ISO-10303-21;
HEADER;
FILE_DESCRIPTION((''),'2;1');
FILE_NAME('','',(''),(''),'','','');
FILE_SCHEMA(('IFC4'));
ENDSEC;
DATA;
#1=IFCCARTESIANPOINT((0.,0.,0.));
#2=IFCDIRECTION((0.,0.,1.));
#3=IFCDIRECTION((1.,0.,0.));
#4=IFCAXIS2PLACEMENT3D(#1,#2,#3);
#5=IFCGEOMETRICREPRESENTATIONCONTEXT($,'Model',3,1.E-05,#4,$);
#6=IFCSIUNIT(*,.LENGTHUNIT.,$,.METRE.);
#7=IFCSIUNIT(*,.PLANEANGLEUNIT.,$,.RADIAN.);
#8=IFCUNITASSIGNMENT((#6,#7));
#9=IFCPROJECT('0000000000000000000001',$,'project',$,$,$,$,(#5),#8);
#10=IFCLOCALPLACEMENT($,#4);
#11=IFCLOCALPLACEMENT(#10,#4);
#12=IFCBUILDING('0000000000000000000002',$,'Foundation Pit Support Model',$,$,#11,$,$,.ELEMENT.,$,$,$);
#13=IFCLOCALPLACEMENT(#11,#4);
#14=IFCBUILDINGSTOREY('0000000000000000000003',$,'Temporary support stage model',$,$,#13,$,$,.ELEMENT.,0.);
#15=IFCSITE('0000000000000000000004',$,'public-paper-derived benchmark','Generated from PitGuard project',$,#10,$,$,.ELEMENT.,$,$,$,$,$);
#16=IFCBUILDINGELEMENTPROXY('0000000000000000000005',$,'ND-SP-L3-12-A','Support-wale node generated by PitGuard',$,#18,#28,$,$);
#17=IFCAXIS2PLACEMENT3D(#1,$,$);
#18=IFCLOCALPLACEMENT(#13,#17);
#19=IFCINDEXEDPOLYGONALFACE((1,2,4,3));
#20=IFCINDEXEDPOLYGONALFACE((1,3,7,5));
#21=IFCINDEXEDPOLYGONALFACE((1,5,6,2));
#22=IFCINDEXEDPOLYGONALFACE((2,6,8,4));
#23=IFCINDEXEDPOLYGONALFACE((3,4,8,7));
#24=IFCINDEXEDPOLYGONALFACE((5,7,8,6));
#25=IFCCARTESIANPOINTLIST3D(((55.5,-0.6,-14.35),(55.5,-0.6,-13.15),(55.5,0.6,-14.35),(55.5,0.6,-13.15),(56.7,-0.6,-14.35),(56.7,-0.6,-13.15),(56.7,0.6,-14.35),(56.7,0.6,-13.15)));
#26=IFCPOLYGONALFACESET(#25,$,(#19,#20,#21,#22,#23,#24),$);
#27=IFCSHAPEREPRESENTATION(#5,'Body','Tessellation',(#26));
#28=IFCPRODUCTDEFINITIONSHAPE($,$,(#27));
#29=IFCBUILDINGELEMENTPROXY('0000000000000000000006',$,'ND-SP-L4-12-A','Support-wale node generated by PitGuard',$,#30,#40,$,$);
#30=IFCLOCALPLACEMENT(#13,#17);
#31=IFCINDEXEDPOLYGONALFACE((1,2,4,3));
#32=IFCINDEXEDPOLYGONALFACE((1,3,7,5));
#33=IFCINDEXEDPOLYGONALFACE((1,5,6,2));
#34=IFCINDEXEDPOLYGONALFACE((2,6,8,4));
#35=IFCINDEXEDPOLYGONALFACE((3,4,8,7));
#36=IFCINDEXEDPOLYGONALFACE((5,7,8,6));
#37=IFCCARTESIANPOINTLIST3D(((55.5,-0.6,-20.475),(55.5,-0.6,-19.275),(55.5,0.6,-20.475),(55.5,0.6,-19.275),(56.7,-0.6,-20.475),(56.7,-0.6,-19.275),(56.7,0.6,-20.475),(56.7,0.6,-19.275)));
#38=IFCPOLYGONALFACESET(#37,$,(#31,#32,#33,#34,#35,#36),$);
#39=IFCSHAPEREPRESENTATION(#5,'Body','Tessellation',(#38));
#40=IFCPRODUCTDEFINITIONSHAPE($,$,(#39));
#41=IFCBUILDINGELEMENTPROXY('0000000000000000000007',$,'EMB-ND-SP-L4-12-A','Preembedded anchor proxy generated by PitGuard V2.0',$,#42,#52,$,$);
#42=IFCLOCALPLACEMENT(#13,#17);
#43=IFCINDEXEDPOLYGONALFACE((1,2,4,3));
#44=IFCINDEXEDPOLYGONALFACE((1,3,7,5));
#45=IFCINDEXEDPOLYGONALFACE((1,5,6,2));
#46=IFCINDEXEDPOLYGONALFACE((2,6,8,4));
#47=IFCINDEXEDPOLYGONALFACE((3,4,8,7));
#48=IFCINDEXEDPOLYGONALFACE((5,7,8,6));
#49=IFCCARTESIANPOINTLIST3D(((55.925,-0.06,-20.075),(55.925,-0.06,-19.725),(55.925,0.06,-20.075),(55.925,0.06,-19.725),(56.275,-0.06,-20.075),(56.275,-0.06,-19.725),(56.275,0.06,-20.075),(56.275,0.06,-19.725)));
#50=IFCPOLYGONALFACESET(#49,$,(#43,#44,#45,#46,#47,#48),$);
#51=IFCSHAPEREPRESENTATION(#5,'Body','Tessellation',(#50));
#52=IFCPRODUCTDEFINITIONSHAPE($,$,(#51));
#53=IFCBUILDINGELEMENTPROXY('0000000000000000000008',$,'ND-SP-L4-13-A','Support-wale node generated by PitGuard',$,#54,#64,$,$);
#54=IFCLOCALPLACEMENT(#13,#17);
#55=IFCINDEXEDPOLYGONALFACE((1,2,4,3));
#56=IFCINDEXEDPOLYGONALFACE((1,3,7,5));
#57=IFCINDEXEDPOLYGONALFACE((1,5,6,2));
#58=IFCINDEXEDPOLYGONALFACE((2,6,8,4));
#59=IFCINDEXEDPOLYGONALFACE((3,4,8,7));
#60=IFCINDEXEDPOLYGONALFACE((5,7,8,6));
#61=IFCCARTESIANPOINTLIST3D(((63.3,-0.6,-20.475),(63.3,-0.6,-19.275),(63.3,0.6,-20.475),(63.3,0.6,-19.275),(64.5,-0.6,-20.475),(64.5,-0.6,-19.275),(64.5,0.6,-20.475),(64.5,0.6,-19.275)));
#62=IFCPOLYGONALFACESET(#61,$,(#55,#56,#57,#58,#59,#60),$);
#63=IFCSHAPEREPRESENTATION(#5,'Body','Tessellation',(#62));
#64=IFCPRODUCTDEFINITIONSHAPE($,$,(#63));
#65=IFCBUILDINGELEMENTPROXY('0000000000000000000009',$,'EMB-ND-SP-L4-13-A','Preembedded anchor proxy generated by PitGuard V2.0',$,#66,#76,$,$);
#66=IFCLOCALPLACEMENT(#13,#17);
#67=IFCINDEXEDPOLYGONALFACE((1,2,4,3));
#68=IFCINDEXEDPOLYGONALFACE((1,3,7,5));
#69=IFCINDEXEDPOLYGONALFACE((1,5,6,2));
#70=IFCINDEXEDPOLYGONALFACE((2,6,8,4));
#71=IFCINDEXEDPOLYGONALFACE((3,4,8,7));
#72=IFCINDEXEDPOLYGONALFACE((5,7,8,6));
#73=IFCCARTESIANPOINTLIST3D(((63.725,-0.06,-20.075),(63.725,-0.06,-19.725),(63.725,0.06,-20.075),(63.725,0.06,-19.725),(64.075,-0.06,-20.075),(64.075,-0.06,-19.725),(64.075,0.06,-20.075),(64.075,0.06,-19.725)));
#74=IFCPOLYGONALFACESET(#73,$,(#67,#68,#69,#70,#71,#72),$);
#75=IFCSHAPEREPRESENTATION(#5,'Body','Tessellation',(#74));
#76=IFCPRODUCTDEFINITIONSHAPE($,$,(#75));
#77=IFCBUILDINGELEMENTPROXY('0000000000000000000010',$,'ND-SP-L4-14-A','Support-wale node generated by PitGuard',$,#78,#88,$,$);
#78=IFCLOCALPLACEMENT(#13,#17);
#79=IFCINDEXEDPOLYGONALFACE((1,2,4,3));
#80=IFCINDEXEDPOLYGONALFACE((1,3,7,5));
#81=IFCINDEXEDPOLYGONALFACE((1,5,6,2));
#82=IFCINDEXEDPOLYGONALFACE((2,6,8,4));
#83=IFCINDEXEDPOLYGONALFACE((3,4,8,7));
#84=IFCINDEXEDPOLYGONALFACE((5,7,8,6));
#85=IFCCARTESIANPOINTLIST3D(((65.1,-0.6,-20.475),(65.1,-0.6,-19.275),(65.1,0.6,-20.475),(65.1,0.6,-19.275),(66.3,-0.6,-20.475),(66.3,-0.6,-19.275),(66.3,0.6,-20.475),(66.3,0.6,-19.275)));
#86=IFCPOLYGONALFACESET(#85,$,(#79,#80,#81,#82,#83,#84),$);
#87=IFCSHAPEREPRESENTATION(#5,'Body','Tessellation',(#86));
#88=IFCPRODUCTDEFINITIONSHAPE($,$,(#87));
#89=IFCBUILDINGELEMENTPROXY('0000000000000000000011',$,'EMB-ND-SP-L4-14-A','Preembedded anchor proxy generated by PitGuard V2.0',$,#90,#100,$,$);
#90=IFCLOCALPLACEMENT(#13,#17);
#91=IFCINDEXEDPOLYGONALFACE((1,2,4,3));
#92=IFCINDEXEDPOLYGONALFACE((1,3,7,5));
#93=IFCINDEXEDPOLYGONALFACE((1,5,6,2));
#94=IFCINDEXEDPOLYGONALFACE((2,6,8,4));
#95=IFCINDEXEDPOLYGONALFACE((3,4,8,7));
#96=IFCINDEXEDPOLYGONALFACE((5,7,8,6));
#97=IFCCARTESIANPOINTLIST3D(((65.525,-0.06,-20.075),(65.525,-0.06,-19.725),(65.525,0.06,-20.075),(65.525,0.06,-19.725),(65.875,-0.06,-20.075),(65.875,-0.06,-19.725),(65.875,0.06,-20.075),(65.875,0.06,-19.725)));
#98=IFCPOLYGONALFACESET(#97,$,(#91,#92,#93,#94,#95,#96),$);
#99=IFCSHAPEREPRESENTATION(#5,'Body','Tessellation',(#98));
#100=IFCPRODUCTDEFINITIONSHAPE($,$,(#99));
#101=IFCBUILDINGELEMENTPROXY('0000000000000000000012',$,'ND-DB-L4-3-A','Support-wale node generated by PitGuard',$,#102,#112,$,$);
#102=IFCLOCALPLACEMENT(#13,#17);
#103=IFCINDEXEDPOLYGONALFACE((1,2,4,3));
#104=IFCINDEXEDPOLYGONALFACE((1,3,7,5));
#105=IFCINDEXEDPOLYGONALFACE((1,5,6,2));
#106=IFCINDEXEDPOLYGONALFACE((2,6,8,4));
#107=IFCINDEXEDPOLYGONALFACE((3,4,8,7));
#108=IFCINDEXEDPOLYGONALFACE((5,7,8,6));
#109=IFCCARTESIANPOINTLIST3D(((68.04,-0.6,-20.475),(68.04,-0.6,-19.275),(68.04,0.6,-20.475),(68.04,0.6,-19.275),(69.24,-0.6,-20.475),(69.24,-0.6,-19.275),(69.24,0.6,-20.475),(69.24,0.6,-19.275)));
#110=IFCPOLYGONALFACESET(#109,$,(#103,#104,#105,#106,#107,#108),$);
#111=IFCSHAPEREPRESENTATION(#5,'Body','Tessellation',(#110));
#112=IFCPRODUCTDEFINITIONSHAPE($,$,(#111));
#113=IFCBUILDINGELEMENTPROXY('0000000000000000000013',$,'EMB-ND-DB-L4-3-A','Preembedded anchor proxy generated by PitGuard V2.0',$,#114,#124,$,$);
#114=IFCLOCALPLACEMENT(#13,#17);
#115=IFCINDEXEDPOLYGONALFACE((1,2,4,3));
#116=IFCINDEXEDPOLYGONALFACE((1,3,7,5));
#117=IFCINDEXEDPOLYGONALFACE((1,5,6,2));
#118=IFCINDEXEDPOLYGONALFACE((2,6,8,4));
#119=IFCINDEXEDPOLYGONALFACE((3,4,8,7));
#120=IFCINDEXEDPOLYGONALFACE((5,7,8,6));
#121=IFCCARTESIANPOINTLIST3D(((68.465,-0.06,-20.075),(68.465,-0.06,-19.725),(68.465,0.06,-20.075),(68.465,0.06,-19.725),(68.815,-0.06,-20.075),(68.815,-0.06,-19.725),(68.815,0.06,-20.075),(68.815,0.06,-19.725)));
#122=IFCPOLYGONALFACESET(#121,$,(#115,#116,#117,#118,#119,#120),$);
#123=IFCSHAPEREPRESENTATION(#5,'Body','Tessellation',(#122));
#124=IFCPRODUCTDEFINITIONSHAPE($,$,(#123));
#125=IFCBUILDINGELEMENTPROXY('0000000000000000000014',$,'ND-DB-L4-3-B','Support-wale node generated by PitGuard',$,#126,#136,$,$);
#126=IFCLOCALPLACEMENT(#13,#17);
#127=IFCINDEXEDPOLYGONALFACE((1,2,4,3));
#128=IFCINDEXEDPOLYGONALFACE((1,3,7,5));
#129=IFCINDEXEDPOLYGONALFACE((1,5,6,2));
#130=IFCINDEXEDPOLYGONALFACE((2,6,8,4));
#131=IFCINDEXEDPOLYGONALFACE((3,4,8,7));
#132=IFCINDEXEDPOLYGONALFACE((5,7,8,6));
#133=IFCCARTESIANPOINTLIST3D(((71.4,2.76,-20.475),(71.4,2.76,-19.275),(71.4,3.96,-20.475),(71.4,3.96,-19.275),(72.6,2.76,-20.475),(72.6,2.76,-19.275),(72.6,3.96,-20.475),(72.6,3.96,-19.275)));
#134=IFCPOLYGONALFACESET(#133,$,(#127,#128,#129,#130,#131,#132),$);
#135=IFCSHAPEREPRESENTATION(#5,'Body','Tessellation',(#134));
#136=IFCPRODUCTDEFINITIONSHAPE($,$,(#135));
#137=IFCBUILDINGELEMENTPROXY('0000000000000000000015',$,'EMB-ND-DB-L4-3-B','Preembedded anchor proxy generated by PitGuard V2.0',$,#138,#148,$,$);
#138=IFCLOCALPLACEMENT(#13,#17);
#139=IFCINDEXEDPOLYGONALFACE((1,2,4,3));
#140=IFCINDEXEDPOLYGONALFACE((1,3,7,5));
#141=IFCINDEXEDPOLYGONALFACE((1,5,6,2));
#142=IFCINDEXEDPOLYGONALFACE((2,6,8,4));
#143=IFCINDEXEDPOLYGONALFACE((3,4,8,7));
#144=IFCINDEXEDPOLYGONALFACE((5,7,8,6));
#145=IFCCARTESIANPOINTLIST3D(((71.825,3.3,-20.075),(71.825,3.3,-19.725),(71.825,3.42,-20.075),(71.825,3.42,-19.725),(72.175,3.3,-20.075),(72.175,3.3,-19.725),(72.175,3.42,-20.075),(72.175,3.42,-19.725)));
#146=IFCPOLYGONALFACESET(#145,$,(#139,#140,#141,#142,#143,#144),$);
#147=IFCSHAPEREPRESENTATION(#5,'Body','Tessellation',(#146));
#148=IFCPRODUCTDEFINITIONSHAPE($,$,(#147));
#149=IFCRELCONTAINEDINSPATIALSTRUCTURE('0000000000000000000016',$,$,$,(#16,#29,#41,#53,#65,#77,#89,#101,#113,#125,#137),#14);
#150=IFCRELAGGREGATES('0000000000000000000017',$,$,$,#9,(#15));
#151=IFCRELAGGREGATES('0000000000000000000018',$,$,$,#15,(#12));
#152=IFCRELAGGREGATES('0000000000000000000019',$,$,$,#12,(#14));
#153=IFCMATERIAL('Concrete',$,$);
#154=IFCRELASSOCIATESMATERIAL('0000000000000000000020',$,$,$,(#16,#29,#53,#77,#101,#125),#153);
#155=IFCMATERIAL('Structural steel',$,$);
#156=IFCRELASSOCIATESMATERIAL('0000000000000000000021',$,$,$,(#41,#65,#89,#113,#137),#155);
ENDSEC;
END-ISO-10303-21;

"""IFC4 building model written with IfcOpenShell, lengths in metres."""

from ifc_helpers import new_model, si_unit, frame, origin_with_axes, origin_2d, place, context, project, spatial, rectangle, extrude, material, element, save


model = new_model("IFC4")

# Units and contexts
model_context = context("Model", 3, precision=1e-05, world=origin_with_axes())
ifc_project = project(units=[si_unit("LENGTHUNIT", "METRE"), si_unit("PLANEANGLEUNIT", "RADIAN")], contexts=[model_context])

# Site, building, storey
site_placement = place(None, origin_with_axes())
site = spatial("IfcSite", under=ifc_project, at=site_placement, Name="public-paper-derived benchmark", Description="Generated from PitGuard project", CompositionType="ELEMENT")
building_placement = place(site_placement, origin_with_axes())
building = spatial("IfcBuilding", under=site, at=building_placement, Name="Foundation Pit Support Model", CompositionType="ELEMENT")
storey_placement = place(building_placement, origin_with_axes())
storey = spatial("IfcBuildingStorey", under=building, at=storey_placement, Name="Temporary support stage model", CompositionType="ELEMENT", Elevation=0.0)

# Shared definitions
ifc_material_1 = material(Name="Concrete")

# Shared definitions
ifc_material_2 = material(Name="Structural steel")

# Building element proxies
for number, where, z_axis, x_axis, name in (
    (1, (56.1, 0.0, -14.35), (0.0, 0.0, 1.0), (1.0, 0.0, 0.0), "ND-SP-L3-12-A"),
    (2, (56.1, 0.0, -20.475), (0.0, 0.0, 1.0), (1.0, 0.0, 0.0), "ND-SP-L4-12-A"),
):
    element("IfcBuildingElementProxy", number, at=place(storey_placement, frame(where, z_axis=z_axis, x_axis=x_axis)), inside=storey, material=ifc_material_1, Name=name, Description="Support-wale node generated by PitGuard", context=model_context, shape_type="SweptSolid", body=[
        extrude(rectangle(XDim=1.2, YDim=1.2, at=origin_2d()), origin_with_axes(), (0.0, 0.0, 1.0), 1.2),
    ])
proxy_1_placement = place(storey_placement, frame((56.1, 0.0, -20.075), z_axis=(0.0, 0.0, 1.0), x_axis=(1.0, 0.0, 0.0)))
element("IfcBuildingElementProxy", 3, at=proxy_1_placement, inside=storey, material=ifc_material_2, Name="EMB-ND-SP-L4-12-A", Description="Preembedded anchor proxy generated by PitGuard V2.0", context=model_context, shape_type="SweptSolid", body=[
    extrude(rectangle(XDim=0.35, YDim=0.12, at=origin_2d()), origin_with_axes(), (0.0, 0.0, 1.0), 0.35),
])
proxy_2_placement = place(storey_placement, frame((63.9, 0.0, -20.475), z_axis=(0.0, 0.0, 1.0), x_axis=(1.0, 0.0, 0.0)))
element("IfcBuildingElementProxy", 4, at=proxy_2_placement, inside=storey, material=ifc_material_1, Name="ND-SP-L4-13-A", Description="Support-wale node generated by PitGuard", context=model_context, shape_type="SweptSolid", body=[
    extrude(rectangle(XDim=1.2, YDim=1.2, at=origin_2d()), origin_with_axes(), (0.0, 0.0, 1.0), 1.2),
])
proxy_3_placement = place(storey_placement, frame((63.9, 0.0, -20.075), z_axis=(0.0, 0.0, 1.0), x_axis=(1.0, 0.0, 0.0)))
element("IfcBuildingElementProxy", 5, at=proxy_3_placement, inside=storey, material=ifc_material_2, Name="EMB-ND-SP-L4-13-A", Description="Preembedded anchor proxy generated by PitGuard V2.0", context=model_context, shape_type="SweptSolid", body=[
    extrude(rectangle(XDim=0.35, YDim=0.12, at=origin_2d()), origin_with_axes(), (0.0, 0.0, 1.0), 0.35),
])
proxy_4_placement = place(storey_placement, frame((65.7, 0.0, -20.475), z_axis=(0.0, 0.0, 1.0), x_axis=(1.0, 0.0, 0.0)))
element("IfcBuildingElementProxy", 6, at=proxy_4_placement, inside=storey, material=ifc_material_1, Name="ND-SP-L4-14-A", Description="Support-wale node generated by PitGuard", context=model_context, shape_type="SweptSolid", body=[
    extrude(rectangle(XDim=1.2, YDim=1.2, at=origin_2d()), origin_with_axes(), (0.0, 0.0, 1.0), 1.2),
])
proxy_5_placement = place(storey_placement, frame((65.7, 0.0, -20.075), z_axis=(0.0, 0.0, 1.0), x_axis=(1.0, 0.0, 0.0)))
element("IfcBuildingElementProxy", 7, at=proxy_5_placement, inside=storey, material=ifc_material_2, Name="EMB-ND-SP-L4-14-A", Description="Preembedded anchor proxy generated by PitGuard V2.0", context=model_context, shape_type="SweptSolid", body=[
    extrude(rectangle(XDim=0.35, YDim=0.12, at=origin_2d()), origin_with_axes(), (0.0, 0.0, 1.0), 0.35),
])
proxy_6_placement = place(storey_placement, frame((68.64, 0.0, -20.475), z_axis=(0.0, 0.0, 1.0), x_axis=(1.0, 0.0, 0.0)))
element("IfcBuildingElementProxy", 8, at=proxy_6_placement, inside=storey, material=ifc_material_1, Name="ND-DB-L4-3-A", Description="Support-wale node generated by PitGuard", context=model_context, shape_type="SweptSolid", body=[
    extrude(rectangle(XDim=1.2, YDim=1.2, at=origin_2d()), origin_with_axes(), (0.0, 0.0, 1.0), 1.2),
])
proxy_7_placement = place(storey_placement, frame((68.64, 0.0, -20.075), z_axis=(0.0, 0.0, 1.0), x_axis=(1.0, 0.0, 0.0)))
element("IfcBuildingElementProxy", 9, at=proxy_7_placement, inside=storey, material=ifc_material_2, Name="EMB-ND-DB-L4-3-A", Description="Preembedded anchor proxy generated by PitGuard V2.0", context=model_context, shape_type="SweptSolid", body=[
    extrude(rectangle(XDim=0.35, YDim=0.12, at=origin_2d()), origin_with_axes(), (0.0, 0.0, 1.0), 0.35),
])
proxy_8_placement = place(storey_placement, frame((72.0, 3.36, -20.475), z_axis=(0.0, 0.0, 1.0), x_axis=(1.0, 0.0, 0.0)))
element("IfcBuildingElementProxy", 10, at=proxy_8_placement, inside=storey, material=ifc_material_1, Name="ND-DB-L4-3-B", Description="Support-wale node generated by PitGuard", context=model_context, shape_type="SweptSolid", body=[
    extrude(rectangle(XDim=1.2, YDim=1.2, at=origin_2d()), origin_with_axes(), (0.0, 0.0, 1.0), 1.2),
])
proxy_9_placement = place(storey_placement, frame((72.0, 3.36, -20.075), z_axis=(0.0, 0.0, 1.0), x_axis=(1.0, 0.0, 0.0)))
element("IfcBuildingElementProxy", 11, at=proxy_9_placement, inside=storey, material=ifc_material_2, Name="EMB-ND-DB-L4-3-B", Description="Preembedded anchor proxy generated by PitGuard V2.0", context=model_context, shape_type="SweptSolid", body=[
    extrude(rectangle(XDim=0.35, YDim=0.12, at=origin_2d()), origin_with_axes(), (0.0, 0.0, 1.0), 0.35),
])

save(model, "model.ifc")
